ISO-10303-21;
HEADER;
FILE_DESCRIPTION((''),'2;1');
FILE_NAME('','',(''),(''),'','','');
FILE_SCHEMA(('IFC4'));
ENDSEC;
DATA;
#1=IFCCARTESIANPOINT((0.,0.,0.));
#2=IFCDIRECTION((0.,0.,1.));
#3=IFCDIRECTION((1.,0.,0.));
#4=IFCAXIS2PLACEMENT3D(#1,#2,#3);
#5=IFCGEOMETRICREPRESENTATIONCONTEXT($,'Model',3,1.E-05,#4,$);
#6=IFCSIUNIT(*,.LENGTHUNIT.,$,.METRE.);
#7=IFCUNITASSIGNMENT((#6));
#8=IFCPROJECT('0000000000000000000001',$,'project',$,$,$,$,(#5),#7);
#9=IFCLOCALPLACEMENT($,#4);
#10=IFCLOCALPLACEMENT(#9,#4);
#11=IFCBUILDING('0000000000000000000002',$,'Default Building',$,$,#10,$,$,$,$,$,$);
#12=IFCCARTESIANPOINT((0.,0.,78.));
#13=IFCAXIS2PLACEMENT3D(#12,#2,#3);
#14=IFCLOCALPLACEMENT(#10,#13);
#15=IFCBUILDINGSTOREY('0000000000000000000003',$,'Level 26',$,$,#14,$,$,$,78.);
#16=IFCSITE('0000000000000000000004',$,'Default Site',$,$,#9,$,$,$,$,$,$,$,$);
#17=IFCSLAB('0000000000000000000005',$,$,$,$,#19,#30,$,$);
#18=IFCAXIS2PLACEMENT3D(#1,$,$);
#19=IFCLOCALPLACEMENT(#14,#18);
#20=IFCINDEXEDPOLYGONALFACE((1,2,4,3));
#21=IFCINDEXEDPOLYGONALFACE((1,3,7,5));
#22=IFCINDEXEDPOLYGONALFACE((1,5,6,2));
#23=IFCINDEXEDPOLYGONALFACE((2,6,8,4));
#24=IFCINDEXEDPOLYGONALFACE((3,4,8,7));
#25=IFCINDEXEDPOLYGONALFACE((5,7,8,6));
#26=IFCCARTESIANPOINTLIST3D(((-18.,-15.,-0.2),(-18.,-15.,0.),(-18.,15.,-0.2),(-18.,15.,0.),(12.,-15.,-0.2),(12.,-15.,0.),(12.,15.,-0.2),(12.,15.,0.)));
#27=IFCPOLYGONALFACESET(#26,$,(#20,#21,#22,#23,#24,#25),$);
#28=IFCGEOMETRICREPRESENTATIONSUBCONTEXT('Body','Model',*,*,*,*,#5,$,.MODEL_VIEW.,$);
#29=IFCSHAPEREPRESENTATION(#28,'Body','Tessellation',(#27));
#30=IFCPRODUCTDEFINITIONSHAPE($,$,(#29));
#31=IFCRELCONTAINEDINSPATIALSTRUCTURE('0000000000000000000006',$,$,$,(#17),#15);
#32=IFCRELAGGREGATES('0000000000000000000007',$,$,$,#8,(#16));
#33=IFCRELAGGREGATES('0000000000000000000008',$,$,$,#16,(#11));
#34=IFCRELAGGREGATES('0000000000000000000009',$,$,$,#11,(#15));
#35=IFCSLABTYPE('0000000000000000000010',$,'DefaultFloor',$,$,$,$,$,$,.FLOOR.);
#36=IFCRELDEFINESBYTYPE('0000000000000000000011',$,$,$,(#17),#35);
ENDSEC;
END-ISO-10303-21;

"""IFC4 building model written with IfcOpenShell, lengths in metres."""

from ifc_helpers import new_model, si_unit, frame, origin_with_axes, place, context, subcontext, project, spatial, polyline, outline, extrude, type_object, element, save


model = new_model("IFC4")

# Units and contexts
model_context = context("Model", 3, precision=1e-05, world=origin_with_axes())
body_context = subcontext(model_context, "Body", "Model", "MODEL_VIEW")
ifc_project = project(units=[si_unit("LENGTHUNIT", "METRE")], contexts=[model_context])

# Site, building, storey
site_placement = place(None, origin_with_axes())
site = spatial("IfcSite", under=ifc_project, at=site_placement, Name="Default Site")
building_placement = place(site_placement, origin_with_axes())
building = spatial("IfcBuilding", under=site, at=building_placement, Name="Default Building")
storey_placement = place(building_placement, frame((0.0, 0.0, 78.0), z_axis=(0.0, 0.0, 1.0), x_axis=(1.0, 0.0, 0.0)))
storey = spatial("IfcBuildingStorey", under=building, at=storey_placement, Name="Level 26", Elevation=78.0)

# Slab
slab_type = type_object("IfcSlabType", Name="DefaultFloor", PredefinedType="FLOOR")
slab_placement = place(storey_placement, frame((0.0, 0.0, -78.0), z_axis=(0.0, 0.0, 1.0), x_axis=(1.0, 0.0, 0.0)))
element("IfcSlab", 1, at=slab_placement, inside=storey, type_object=slab_type, context=body_context, shape_type="SweptSolid", body=[
    extrude(outline(polyline([(-18.0, 15.0), (12.0, 15.0), (12.0, -15.0), (-18.0, -15.0), (-18.0, 15.0)])), frame((0.0, 0.0, 78.0), z_axis=(0.0, 0.0, 1.0), x_axis=(1.0, 0.0, 0.0)), (0.0, 0.0, -1.0), 0.2),
])

save(model, "model.ifc")
